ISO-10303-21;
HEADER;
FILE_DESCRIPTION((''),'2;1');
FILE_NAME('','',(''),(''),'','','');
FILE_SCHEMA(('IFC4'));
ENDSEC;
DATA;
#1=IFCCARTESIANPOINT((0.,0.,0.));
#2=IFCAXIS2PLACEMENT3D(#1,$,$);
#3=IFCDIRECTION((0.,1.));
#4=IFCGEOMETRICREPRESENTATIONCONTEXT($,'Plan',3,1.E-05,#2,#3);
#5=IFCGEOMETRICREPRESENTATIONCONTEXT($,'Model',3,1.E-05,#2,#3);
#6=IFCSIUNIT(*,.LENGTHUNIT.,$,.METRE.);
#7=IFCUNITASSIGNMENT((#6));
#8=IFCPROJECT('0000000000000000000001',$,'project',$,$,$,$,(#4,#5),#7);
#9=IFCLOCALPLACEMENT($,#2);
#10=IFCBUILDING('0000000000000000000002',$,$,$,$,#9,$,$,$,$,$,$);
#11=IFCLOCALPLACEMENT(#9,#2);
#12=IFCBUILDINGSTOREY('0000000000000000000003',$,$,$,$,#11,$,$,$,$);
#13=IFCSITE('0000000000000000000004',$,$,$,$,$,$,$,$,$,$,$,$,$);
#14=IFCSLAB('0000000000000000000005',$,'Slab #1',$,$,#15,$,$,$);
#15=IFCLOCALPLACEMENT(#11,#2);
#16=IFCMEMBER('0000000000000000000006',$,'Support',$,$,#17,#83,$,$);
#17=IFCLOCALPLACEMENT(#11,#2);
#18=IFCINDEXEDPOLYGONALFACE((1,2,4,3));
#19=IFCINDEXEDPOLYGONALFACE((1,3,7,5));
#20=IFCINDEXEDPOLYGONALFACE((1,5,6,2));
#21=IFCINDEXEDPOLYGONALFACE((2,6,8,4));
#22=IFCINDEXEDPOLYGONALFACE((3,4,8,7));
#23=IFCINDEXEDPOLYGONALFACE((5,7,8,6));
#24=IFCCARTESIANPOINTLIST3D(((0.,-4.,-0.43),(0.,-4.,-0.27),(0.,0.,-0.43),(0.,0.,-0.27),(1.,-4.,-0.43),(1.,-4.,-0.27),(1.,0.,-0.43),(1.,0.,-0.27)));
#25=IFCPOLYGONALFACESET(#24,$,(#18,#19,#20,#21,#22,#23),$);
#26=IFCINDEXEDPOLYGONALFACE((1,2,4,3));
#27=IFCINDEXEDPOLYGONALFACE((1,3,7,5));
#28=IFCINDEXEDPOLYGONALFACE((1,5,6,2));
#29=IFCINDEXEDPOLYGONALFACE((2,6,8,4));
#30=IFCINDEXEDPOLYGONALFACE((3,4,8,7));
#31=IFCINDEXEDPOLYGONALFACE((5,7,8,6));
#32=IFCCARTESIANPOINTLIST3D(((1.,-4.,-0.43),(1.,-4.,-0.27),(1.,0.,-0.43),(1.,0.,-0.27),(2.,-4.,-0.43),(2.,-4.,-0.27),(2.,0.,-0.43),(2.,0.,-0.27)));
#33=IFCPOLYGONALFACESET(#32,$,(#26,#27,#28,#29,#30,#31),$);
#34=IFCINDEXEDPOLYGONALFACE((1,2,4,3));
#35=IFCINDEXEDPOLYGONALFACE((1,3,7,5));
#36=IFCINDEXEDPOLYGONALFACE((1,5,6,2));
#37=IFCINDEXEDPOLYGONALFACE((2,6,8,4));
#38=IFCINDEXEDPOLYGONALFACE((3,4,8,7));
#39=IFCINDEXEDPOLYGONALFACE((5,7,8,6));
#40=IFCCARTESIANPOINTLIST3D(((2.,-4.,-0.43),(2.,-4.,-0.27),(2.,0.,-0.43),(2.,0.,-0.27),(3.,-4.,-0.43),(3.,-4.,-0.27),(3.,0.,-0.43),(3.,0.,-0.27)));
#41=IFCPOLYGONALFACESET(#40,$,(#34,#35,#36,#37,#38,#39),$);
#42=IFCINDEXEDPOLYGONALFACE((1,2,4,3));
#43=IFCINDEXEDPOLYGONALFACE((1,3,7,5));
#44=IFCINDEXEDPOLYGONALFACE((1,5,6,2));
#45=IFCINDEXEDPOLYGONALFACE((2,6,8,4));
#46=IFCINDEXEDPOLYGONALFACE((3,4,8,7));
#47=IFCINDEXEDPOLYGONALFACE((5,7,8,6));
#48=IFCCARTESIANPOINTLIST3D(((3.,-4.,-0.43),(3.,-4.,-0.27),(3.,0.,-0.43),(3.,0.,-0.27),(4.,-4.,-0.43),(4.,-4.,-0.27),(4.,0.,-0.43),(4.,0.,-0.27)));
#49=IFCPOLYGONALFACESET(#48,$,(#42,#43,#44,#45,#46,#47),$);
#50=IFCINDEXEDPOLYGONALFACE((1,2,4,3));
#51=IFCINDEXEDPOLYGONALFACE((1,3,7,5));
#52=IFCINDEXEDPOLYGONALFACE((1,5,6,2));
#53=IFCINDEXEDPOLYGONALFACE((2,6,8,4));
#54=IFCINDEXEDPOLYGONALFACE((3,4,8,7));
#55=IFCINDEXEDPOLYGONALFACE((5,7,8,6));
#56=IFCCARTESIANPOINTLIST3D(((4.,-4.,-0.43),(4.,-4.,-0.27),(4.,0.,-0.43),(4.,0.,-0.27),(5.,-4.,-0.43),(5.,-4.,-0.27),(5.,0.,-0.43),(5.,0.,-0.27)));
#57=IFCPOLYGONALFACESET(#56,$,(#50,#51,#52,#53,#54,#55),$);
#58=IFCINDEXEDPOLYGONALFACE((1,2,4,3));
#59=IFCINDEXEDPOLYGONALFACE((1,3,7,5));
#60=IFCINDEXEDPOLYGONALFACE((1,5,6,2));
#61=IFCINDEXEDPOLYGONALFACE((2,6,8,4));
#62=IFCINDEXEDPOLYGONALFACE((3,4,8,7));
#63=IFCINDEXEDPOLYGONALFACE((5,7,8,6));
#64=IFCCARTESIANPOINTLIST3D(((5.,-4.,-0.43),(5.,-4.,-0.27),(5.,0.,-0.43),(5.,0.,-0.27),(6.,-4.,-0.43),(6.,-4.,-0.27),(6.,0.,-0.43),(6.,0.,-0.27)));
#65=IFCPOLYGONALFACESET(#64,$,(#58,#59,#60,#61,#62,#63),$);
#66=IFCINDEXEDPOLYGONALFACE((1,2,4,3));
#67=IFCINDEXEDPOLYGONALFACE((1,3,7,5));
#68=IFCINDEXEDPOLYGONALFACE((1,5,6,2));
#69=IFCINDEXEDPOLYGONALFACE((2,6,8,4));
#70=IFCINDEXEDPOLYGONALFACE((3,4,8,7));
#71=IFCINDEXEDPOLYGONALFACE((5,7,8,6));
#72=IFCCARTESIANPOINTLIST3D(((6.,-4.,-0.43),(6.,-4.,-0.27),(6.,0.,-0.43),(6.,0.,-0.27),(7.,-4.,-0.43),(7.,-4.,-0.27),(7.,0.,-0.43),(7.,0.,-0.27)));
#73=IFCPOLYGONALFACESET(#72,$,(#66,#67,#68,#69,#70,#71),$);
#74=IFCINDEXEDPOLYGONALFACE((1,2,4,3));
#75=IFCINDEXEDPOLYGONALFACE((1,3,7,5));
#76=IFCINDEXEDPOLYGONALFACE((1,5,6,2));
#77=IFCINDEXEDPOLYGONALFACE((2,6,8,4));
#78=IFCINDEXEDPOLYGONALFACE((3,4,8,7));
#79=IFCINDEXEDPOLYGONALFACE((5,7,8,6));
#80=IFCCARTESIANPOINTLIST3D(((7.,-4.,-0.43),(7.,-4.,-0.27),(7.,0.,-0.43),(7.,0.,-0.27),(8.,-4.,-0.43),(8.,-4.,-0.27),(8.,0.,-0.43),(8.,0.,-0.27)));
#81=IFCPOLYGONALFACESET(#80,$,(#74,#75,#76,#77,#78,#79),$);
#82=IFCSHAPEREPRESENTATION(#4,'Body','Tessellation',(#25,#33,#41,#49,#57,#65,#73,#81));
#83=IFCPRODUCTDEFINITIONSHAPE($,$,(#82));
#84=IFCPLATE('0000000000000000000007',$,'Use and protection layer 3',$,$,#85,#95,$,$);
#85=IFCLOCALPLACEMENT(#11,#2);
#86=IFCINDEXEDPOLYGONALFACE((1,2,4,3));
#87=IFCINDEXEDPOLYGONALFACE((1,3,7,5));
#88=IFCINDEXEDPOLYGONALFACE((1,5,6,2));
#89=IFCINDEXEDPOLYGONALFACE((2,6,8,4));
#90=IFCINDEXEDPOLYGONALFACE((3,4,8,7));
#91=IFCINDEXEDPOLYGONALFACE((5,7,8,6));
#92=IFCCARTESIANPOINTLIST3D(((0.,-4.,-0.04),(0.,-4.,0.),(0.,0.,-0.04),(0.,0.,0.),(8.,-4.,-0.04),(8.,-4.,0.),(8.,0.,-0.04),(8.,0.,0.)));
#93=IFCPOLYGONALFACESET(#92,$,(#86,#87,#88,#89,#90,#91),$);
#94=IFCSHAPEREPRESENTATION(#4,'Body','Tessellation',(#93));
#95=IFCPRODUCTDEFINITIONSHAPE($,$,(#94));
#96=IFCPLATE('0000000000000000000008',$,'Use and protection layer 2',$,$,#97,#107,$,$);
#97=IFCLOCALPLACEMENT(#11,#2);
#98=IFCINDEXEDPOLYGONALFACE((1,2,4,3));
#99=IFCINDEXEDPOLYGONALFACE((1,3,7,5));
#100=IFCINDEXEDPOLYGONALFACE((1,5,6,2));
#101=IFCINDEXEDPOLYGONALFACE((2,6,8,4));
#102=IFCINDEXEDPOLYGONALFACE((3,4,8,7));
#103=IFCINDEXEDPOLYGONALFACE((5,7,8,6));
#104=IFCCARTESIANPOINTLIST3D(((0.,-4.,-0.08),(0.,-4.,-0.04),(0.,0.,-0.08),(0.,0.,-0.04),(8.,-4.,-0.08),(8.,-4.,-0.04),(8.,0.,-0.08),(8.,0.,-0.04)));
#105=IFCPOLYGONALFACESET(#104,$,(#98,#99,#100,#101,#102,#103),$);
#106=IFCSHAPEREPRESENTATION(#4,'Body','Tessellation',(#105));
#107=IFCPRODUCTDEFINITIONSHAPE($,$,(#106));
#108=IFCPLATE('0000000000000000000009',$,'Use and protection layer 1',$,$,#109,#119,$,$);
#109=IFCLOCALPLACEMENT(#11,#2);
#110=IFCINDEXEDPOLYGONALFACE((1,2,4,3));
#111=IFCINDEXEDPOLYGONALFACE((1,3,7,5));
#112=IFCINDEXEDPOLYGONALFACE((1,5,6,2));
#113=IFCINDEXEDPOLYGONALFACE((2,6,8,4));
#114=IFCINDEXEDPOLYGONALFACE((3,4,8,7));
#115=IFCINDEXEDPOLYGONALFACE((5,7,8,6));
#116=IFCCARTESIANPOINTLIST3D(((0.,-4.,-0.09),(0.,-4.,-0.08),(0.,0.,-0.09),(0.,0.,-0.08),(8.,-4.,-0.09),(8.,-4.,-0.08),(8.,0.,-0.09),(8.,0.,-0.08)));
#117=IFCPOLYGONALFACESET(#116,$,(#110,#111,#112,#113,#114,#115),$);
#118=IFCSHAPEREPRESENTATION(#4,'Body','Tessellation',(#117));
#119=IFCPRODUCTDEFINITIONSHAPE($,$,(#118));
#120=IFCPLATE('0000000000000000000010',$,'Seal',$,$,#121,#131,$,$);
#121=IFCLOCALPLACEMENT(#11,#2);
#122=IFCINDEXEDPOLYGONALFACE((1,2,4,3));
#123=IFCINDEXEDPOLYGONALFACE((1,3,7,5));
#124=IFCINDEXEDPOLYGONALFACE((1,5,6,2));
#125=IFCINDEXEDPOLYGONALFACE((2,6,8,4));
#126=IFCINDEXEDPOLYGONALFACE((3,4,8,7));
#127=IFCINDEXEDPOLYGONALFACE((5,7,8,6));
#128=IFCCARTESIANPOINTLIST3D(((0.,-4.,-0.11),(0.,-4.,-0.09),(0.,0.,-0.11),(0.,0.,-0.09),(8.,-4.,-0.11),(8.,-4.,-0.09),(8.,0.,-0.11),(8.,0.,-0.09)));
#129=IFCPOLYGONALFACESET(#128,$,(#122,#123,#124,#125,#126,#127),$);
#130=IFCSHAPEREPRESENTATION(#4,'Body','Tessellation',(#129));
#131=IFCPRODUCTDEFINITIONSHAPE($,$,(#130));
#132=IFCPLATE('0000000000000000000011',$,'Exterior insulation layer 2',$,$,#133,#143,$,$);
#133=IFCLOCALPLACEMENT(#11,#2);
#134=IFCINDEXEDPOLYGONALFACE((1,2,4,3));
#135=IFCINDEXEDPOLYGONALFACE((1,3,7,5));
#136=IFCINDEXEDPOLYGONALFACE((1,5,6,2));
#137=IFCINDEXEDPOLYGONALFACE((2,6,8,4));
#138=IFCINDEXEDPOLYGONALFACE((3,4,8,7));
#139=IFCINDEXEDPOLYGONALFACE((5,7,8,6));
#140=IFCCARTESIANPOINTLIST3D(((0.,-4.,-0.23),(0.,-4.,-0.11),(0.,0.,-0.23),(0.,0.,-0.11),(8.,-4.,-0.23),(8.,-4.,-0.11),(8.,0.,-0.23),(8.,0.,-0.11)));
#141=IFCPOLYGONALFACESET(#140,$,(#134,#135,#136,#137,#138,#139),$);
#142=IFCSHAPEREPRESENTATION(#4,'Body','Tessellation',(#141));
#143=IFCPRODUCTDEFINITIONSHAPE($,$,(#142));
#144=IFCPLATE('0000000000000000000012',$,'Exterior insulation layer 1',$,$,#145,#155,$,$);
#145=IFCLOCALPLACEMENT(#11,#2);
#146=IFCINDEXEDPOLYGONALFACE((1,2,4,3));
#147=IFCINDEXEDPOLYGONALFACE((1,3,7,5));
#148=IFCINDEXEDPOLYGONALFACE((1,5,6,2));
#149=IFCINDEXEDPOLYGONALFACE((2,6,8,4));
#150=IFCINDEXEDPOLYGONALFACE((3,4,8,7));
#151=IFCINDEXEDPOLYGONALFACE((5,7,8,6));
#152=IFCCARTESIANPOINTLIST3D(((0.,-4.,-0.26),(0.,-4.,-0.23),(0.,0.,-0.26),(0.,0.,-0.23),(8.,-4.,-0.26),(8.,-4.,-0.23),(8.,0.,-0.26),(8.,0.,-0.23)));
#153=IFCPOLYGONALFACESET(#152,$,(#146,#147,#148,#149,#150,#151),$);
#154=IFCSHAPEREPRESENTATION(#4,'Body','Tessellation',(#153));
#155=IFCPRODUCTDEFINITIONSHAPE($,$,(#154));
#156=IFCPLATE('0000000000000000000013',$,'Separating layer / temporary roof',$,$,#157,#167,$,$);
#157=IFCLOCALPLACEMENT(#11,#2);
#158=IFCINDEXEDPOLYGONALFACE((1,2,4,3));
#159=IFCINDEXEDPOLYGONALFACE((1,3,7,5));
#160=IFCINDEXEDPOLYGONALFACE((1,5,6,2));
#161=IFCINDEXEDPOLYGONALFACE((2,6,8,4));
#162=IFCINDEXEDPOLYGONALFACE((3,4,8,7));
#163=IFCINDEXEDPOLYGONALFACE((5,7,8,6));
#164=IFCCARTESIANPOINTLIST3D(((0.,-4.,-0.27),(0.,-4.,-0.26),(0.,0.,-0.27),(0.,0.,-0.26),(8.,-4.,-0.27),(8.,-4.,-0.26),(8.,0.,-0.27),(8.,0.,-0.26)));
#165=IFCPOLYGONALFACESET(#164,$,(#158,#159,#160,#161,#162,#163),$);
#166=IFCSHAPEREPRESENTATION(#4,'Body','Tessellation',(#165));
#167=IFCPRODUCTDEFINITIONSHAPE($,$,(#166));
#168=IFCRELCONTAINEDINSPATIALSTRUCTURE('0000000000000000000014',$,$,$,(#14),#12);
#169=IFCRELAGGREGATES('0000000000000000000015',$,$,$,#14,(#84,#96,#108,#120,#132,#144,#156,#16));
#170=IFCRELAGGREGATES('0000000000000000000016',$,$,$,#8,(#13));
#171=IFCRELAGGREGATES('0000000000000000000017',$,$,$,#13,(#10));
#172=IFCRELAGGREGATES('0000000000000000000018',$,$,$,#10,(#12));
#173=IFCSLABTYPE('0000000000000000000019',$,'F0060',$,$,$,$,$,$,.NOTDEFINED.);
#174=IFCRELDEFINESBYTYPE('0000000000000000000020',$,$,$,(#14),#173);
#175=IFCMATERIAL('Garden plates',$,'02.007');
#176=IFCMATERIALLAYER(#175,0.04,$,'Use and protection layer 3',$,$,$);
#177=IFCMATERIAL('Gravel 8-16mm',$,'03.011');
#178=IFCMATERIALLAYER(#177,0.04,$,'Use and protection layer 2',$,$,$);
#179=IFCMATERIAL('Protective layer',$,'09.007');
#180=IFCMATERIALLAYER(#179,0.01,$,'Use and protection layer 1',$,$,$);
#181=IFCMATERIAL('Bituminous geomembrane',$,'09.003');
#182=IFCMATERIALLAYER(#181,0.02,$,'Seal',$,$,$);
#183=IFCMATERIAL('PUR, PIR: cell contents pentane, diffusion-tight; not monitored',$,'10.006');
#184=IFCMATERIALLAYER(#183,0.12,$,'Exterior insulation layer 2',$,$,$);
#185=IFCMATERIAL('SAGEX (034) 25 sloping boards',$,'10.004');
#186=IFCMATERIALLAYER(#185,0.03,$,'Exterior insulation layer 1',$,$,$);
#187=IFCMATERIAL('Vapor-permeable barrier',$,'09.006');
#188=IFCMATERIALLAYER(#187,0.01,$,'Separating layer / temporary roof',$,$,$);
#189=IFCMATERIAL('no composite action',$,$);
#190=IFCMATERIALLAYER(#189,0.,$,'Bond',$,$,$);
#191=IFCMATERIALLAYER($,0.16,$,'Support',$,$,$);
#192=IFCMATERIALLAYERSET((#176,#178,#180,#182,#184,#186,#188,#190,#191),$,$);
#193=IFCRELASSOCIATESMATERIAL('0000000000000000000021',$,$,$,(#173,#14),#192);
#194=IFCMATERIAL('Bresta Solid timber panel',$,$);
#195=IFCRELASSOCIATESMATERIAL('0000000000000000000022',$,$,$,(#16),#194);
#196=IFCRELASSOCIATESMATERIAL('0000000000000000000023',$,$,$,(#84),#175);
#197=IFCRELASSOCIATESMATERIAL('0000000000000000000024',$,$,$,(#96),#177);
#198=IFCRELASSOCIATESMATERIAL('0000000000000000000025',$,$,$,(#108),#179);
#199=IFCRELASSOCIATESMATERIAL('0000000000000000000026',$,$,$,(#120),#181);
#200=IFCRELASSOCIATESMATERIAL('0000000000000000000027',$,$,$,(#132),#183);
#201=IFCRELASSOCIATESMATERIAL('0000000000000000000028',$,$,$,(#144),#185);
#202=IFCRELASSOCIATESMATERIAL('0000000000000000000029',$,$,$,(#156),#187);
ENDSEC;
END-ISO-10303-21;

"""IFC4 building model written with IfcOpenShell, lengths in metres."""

from ifc_helpers import new_model, si_unit, direction, frame, frame_2d, origin, origin_with_axes, place, context, project, spatial, rectangle, extrude, material, layer, layer_set, type_object, element, aggregate, save


model = new_model("IFC4")

# Units and contexts
plan_context = context("Plan", 3, precision=1e-05, world=origin(), true_north=direction((0.0, 1.0)))
model_context = context("Model", 3, precision=1e-05, world=origin(), true_north=direction((0.0, 1.0)))
ifc_project = project(units=[si_unit("LENGTHUNIT", "METRE")], contexts=[plan_context, model_context])

# Site, building, storey
site = spatial("IfcSite", under=ifc_project)
building_placement = place(None, origin())
building = spatial("IfcBuilding", under=site, at=building_placement)
storey_placement = place(building_placement, origin())
storey = spatial("IfcBuildingStorey", under=building, at=storey_placement)

# Slab, member, plates
ifc_material_1 = material(Name="Garden plates", Category="02.007")
ifc_layer_1 = layer(ifc_material_1, 0.04, Name="Use and protection layer 3")
ifc_material_2 = material(Name="Gravel 8-16mm", Category="03.011")
ifc_layer_2 = layer(ifc_material_2, 0.04, Name="Use and protection layer 2")
ifc_material_3 = material(Name="Protective layer", Category="09.007")
ifc_layer_3 = layer(ifc_material_3, 0.01, Name="Use and protection layer 1")
ifc_material_4 = material(Name="Bituminous geomembrane", Category="09.003")
ifc_layer_4 = layer(ifc_material_4, 0.02, Name="Seal")
ifc_material_5 = material(Name="PUR, PIR: cell contents pentane, diffusion-tight; not monitored", Category="10.006")
ifc_layer_5 = layer(ifc_material_5, 0.12, Name="Exterior insulation layer 2")
ifc_material_6 = material(Name="SAGEX (034) 25 sloping boards", Category="10.004")
ifc_layer_6 = layer(ifc_material_6, 0.03, Name="Exterior insulation layer 1")
ifc_material_7 = material(Name="Vapor-permeable barrier", Category="09.006")
ifc_layer_7 = layer(ifc_material_7, 0.01, Name="Separating layer / temporary roof")
ifc_material_8 = material(Name="no composite action")
ifc_layer_8 = layer(ifc_material_8, 0.0, Name="Bond")
ifc_layer_9 = layer(None, 0.16, Name="Support")
ifc_layer_set = layer_set([ifc_layer_1, ifc_layer_2, ifc_layer_3, ifc_layer_4, ifc_layer_5, ifc_layer_6, ifc_layer_7, ifc_layer_8, ifc_layer_9])
slab_type = type_object("IfcSlabType", Name="F0060", PredefinedType="NOTDEFINED", material=ifc_layer_set)
slab_placement = place(None, frame((0.0, 0.0, 0.0), z_axis=(0.0, 0.0, -1.0), x_axis=(1.0, 0.0, 0.0)))
slab = element("IfcSlab", 1, at=slab_placement, inside=storey, type_object=slab_type, material=ifc_layer_set, Name="Slab #1")
ifc_material_9 = material(Name="Bresta Solid timber panel")
member_placement = place(slab_placement, origin())
member = element("IfcMember", 2, at=member_placement, material=ifc_material_9, Name="Support", context=plan_context, shape_type="SweptSolid", body=[
    extrude(rectangle(XDim=1.0, YDim=0.16, at=frame_2d((0.5, 0.08), x_axis=(1.0, 0.0))), frame((0.0, 4.0, 0.27), z_axis=(0.0, -1.0, 0.0), x_axis=(1.0, 0.0, 0.0)), (0.0, 0.0, 1.0), 4.0),
    extrude(rectangle(XDim=1.0, YDim=0.16, at=frame_2d((0.5, 0.08), x_axis=(1.0, 0.0))), frame((1.0, 4.0, 0.27), z_axis=(0.0, -1.0, 0.0), x_axis=(1.0, 0.0, 0.0)), (0.0, 0.0, 1.0), 4.0),
    extrude(rectangle(XDim=1.0, YDim=0.16, at=frame_2d((0.5, 0.08), x_axis=(1.0, 0.0))), frame((2.0, 4.0, 0.27), z_axis=(0.0, -1.0, 0.0), x_axis=(1.0, 0.0, 0.0)), (0.0, 0.0, 1.0), 4.0),
    extrude(rectangle(XDim=1.0, YDim=0.16, at=frame_2d((0.5, 0.08), x_axis=(1.0, 0.0))), frame((3.0, 4.0, 0.27), z_axis=(0.0, -1.0, 0.0), x_axis=(1.0, 0.0, 0.0)), (0.0, 0.0, 1.0), 4.0),
    extrude(rectangle(XDim=1.0, YDim=0.16, at=frame_2d((0.5, 0.08), x_axis=(1.0, 0.0))), frame((4.0, 4.0, 0.27), z_axis=(0.0, -1.0, 0.0), x_axis=(1.0, 0.0, 0.0)), (0.0, 0.0, 1.0), 4.0),
    extrude(rectangle(XDim=1.0, YDim=0.16, at=frame_2d((0.5, 0.08), x_axis=(1.0, 0.0))), frame((5.0, 4.0, 0.27), z_axis=(0.0, -1.0, 0.0), x_axis=(1.0, 0.0, 0.0)), (0.0, 0.0, 1.0), 4.0),
    extrude(rectangle(XDim=1.0, YDim=0.16, at=frame_2d((0.5, 0.08), x_axis=(1.0, 0.0))), frame((6.0, 4.0, 0.27), z_axis=(0.0, -1.0, 0.0), x_axis=(1.0, 0.0, 0.0)), (0.0, 0.0, 1.0), 4.0),
    extrude(rectangle(XDim=1.0, YDim=0.16, at=frame_2d((0.5, 0.08), x_axis=(1.0, 0.0))), frame((7.0, 4.0, 0.27), z_axis=(0.0, -1.0, 0.0), x_axis=(1.0, 0.0, 0.0)), (0.0, 0.0, 1.0), 4.0),
])
plate_1_placement = place(slab_placement, origin())
plate_1 = element("IfcPlate", 3, at=plate_1_placement, material=ifc_material_1, Name="Use and protection layer 3", context=plan_context, shape_type="SweptSolid", body=[
    extrude(rectangle(XDim=8.0, YDim=4.0, at=frame_2d((4.0, 2.0), x_axis=(1.0, 0.0))), origin_with_axes(), (0.0, 0.0, 1.0), 0.04),
])
plate_2_placement = place(slab_placement, origin())
plate_2 = element("IfcPlate", 4, at=plate_2_placement, material=ifc_material_2, Name="Use and protection layer 2", context=plan_context, shape_type="SweptSolid", body=[
    extrude(rectangle(XDim=8.0, YDim=4.0, at=frame_2d((4.0, 2.0), x_axis=(1.0, 0.0))), frame((0.0, 0.0, 0.04), z_axis=(0.0, 0.0, 1.0), x_axis=(1.0, 0.0, 0.0)), (0.0, 0.0, 1.0), 0.04),
])
plate_3_placement = place(slab_placement, origin())
plate_3 = element("IfcPlate", 5, at=plate_3_placement, material=ifc_material_3, Name="Use and protection layer 1", context=plan_context, shape_type="SweptSolid", body=[
    extrude(rectangle(XDim=8.0, YDim=4.0, at=frame_2d((4.0, 2.0), x_axis=(1.0, 0.0))), frame((0.0, 0.0, 0.08), z_axis=(0.0, 0.0, 1.0), x_axis=(1.0, 0.0, 0.0)), (0.0, 0.0, 1.0), 0.01),
])
plate_4_placement = place(slab_placement, origin())
plate_4 = element("IfcPlate", 6, at=plate_4_placement, material=ifc_material_4, Name="Seal", context=plan_context, shape_type="SweptSolid", body=[
    extrude(rectangle(XDim=8.0, YDim=4.0, at=frame_2d((4.0, 2.0), x_axis=(1.0, 0.0))), frame((0.0, 0.0, 0.09), z_axis=(0.0, 0.0, 1.0), x_axis=(1.0, 0.0, 0.0)), (0.0, 0.0, 1.0), 0.02),
])
plate_5_placement = place(slab_placement, origin())
plate_5 = element("IfcPlate", 7, at=plate_5_placement, material=ifc_material_5, Name="Exterior insulation layer 2", context=plan_context, shape_type="SweptSolid", body=[
    extrude(rectangle(XDim=8.0, YDim=4.0, at=frame_2d((4.0, 2.0), x_axis=(1.0, 0.0))), frame((0.0, 0.0, 0.11), z_axis=(0.0, 0.0, 1.0), x_axis=(1.0, 0.0, 0.0)), (0.0, 0.0, 1.0), 0.12),
])
plate_6_placement = place(slab_placement, origin())
plate_6 = element("IfcPlate", 8, at=plate_6_placement, material=ifc_material_6, Name="Exterior insulation layer 1", context=plan_context, shape_type="SweptSolid", body=[
    extrude(rectangle(XDim=8.0, YDim=4.0, at=frame_2d((4.0, 2.0), x_axis=(1.0, 0.0))), frame((0.0, 0.0, 0.23), z_axis=(0.0, 0.0, 1.0), x_axis=(1.0, 0.0, 0.0)), (0.0, 0.0, 1.0), 0.03),
])
plate_7_placement = place(slab_placement, origin())
plate_7 = element("IfcPlate", 9, at=plate_7_placement, material=ifc_material_7, Name="Separating layer / temporary roof", context=plan_context, shape_type="SweptSolid", body=[
    extrude(rectangle(XDim=8.0, YDim=4.0, at=frame_2d((4.0, 2.0), x_axis=(1.0, 0.0))), frame((0.0, 0.0, 0.26), z_axis=(0.0, 0.0, 1.0), x_axis=(1.0, 0.0, 0.0)), (0.0, 0.0, 1.0), 0.01),
])
aggregate(slab, [plate_1, plate_2, plate_3, plate_4, plate_5, plate_6, plate_7, member])

save(model, "model.ifc")
